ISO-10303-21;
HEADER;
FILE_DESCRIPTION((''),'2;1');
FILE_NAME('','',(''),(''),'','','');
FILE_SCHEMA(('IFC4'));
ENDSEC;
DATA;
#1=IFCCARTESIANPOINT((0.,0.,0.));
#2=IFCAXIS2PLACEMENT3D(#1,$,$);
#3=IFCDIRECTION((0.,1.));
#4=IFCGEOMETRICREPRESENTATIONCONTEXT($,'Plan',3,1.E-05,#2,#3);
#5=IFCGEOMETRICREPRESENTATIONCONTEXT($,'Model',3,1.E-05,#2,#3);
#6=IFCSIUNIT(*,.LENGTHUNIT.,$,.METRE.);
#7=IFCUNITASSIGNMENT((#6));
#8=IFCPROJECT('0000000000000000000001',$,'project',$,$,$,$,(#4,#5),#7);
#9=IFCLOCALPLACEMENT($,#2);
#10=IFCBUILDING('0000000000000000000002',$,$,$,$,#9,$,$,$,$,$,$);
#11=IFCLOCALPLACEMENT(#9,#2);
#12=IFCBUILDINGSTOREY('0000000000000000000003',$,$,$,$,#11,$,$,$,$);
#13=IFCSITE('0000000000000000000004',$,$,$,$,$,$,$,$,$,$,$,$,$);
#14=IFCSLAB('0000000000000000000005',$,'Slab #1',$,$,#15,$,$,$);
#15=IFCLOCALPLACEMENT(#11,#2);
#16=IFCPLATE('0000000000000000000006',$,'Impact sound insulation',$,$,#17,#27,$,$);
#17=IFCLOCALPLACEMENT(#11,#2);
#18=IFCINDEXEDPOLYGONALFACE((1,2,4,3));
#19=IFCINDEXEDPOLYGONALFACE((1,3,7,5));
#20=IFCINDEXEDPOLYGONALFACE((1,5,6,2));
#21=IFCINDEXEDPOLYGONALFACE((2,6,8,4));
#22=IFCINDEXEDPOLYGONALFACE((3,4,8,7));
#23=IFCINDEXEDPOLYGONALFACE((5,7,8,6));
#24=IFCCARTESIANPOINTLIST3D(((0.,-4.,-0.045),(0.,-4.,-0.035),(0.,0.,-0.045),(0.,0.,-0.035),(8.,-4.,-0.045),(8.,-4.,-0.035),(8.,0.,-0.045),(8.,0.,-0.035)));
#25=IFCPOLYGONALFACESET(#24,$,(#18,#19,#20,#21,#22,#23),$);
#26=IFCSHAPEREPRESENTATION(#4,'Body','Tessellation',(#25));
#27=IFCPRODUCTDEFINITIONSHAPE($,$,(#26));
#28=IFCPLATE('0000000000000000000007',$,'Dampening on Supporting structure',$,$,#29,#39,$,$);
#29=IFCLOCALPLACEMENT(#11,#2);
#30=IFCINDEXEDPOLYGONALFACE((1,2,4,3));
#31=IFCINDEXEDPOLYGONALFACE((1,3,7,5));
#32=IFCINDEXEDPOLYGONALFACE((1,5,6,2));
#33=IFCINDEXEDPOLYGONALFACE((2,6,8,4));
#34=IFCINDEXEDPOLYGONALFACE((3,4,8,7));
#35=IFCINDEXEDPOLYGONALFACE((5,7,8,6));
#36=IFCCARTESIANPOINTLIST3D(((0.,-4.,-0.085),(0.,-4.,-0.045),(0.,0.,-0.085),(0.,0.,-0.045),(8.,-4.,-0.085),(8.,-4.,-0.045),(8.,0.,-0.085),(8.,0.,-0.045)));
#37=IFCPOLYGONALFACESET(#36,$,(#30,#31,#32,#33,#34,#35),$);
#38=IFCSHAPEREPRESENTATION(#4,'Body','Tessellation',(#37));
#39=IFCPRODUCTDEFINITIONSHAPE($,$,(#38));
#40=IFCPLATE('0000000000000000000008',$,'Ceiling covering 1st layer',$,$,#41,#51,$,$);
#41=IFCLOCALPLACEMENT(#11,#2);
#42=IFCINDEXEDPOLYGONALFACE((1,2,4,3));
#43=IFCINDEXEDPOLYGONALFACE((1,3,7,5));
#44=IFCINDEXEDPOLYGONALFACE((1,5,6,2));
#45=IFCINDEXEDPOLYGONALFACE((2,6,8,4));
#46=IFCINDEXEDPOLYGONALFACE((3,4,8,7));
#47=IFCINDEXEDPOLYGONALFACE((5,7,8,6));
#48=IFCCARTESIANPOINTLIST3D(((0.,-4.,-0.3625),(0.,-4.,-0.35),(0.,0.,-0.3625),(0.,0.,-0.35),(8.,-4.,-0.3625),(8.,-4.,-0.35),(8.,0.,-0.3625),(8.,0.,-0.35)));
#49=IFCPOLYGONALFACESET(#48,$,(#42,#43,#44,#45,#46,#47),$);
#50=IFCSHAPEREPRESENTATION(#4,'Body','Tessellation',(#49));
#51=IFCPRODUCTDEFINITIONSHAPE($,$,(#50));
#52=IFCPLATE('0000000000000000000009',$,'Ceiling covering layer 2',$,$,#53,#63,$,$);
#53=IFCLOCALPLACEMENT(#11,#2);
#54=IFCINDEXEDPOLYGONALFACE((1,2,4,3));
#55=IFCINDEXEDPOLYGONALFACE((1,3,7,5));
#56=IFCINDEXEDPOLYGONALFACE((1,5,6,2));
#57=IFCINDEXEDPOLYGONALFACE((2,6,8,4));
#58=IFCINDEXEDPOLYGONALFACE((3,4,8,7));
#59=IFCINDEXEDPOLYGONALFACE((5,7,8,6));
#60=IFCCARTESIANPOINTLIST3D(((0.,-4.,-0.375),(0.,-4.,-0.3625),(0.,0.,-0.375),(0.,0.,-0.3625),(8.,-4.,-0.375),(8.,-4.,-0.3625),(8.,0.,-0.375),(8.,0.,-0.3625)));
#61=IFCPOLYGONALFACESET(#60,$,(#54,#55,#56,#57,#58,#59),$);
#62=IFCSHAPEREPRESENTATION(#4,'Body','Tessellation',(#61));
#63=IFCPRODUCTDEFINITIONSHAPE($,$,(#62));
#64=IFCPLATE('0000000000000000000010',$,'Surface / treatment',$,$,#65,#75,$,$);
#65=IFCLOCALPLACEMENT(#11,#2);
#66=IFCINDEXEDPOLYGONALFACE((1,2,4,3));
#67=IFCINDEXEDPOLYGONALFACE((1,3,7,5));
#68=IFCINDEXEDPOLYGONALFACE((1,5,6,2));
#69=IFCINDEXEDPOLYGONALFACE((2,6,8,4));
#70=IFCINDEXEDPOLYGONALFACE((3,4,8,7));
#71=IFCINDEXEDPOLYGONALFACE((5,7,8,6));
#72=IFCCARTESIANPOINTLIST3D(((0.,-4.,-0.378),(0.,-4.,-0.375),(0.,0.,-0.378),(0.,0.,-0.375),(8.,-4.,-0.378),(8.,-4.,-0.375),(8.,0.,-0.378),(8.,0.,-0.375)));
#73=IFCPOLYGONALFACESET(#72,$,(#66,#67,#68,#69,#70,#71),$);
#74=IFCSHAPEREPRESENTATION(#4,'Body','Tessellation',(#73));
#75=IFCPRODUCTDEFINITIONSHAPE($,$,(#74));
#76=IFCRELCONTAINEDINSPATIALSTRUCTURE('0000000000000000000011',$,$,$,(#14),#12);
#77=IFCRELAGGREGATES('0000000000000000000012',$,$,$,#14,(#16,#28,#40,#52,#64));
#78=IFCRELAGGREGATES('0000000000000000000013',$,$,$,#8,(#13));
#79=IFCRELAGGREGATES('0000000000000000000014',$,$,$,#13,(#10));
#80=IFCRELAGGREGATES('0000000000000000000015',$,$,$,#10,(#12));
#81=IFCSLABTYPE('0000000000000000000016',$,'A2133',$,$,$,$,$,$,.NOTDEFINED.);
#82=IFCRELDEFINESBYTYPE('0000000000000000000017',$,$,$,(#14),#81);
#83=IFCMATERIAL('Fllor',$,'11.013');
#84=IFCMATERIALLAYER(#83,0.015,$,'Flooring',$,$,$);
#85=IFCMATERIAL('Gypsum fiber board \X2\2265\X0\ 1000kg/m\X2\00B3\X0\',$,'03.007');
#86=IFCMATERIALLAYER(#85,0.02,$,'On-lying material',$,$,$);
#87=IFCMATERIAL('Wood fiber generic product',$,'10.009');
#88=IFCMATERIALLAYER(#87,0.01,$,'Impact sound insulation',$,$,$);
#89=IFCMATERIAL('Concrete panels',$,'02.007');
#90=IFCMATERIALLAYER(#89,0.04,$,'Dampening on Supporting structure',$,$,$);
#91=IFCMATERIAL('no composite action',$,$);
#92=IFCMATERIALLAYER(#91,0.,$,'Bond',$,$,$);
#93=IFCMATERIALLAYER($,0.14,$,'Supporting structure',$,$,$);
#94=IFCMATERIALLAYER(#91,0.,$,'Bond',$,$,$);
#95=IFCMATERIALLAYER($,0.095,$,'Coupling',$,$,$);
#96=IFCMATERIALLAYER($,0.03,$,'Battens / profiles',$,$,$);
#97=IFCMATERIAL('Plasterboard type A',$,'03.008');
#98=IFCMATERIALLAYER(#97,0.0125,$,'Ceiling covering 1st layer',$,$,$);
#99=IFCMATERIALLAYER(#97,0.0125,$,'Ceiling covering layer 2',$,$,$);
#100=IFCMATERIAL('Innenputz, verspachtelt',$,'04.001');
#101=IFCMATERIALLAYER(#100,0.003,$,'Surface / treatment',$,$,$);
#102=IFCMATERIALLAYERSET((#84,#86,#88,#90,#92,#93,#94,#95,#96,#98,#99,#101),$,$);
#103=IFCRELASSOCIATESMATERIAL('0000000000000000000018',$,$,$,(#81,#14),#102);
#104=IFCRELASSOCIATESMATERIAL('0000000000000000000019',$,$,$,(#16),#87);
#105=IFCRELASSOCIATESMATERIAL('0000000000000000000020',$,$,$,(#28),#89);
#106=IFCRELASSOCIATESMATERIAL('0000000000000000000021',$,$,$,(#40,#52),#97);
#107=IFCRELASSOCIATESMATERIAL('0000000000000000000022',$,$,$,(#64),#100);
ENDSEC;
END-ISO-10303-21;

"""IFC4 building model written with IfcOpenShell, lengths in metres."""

from ifc_helpers import new_model, si_unit, direction, frame, frame_2d, origin, place, context, project, spatial, rectangle, extrude, material, layer, layer_set, type_object, element, aggregate, save


model = new_model("IFC4")

# Units and contexts
plan_context = context("Plan", 3, precision=1e-05, world=origin(), true_north=direction((0.0, 1.0)))
model_context = context("Model", 3, precision=1e-05, world=origin(), true_north=direction((0.0, 1.0)))
ifc_project = project(units=[si_unit("LENGTHUNIT", "METRE")], contexts=[plan_context, model_context])

# Site, building, storey
site = spatial("IfcSite", under=ifc_project)
building_placement = place(None, origin())
building = spatial("IfcBuilding", under=site, at=building_placement)
storey_placement = place(building_placement, origin())
storey = spatial("IfcBuildingStorey", under=building, at=storey_placement)

# Slab, plates
ifc_material_1 = material(Name="Fllor", Category="11.013")
ifc_layer_1 = layer(ifc_material_1, 0.015, Name="Flooring")
ifc_material_2 = material(Name="Gypsum fiber board ≥ 1000kg/m³", Category="03.007")
ifc_layer_2 = layer(ifc_material_2, 0.02, Name="On-lying material")
ifc_material_3 = material(Name="Wood fiber generic product", Category="10.009")
ifc_layer_3 = layer(ifc_material_3, 0.01, Name="Impact sound insulation")
ifc_material_4 = material(Name="Concrete panels", Category="02.007")
ifc_layer_4 = layer(ifc_material_4, 0.04, Name="Dampening on Supporting structure")
ifc_material_5 = material(Name="no composite action")
ifc_layer_5 = layer(ifc_material_5, 0.0, Name="Bond")
ifc_layer_6 = layer(None, 0.14, Name="Supporting structure")
ifc_layer_7 = layer(ifc_material_5, 0.0, Name="Bond")
ifc_layer_8 = layer(None, 0.095, Name="Coupling")
ifc_layer_9 = layer(None, 0.03, Name="Battens / profiles")
ifc_material_6 = material(Name="Plasterboard type A", Category="03.008")
ifc_layer_10 = layer(ifc_material_6, 0.0125, Name="Ceiling covering 1st layer")
ifc_layer_11 = layer(ifc_material_6, 0.0125, Name="Ceiling covering layer 2")
ifc_material_7 = material(Name="Innenputz, verspachtelt", Category="04.001")
ifc_layer_12 = layer(ifc_material_7, 0.003, Name="Surface / treatment")
ifc_layer_set = layer_set([ifc_layer_1, ifc_layer_2, ifc_layer_3, ifc_layer_4, ifc_layer_5, ifc_layer_6, ifc_layer_7, ifc_layer_8, ifc_layer_9, ifc_layer_10, ifc_layer_11, ifc_layer_12])
slab_type = type_object("IfcSlabType", Name="A2133", PredefinedType="NOTDEFINED", material=ifc_layer_set)
slab_placement = place(None, frame((0.0, 0.0, 0.0), z_axis=(0.0, 0.0, -1.0), x_axis=(1.0, 0.0, 0.0)))
slab = element("IfcSlab", 1, at=slab_placement, inside=storey, type_object=slab_type, material=ifc_layer_set, Name="Slab #1")
plate_1_placement = place(slab_placement, origin())
plate_1 = element("IfcPlate", 2, at=plate_1_placement, material=ifc_material_3, Name="Impact sound insulation", context=plan_context, shape_type="SweptSolid", body=[
    extrude(rectangle(XDim=8.0, YDim=4.0, at=frame_2d((4.0, 2.0), x_axis=(1.0, 0.0))), frame((0.0, 0.0, 0.035), z_axis=(0.0, 0.0, 1.0), x_axis=(1.0, 0.0, 0.0)), (0.0, 0.0, 1.0), 0.01),
])
plate_2_placement = place(slab_placement, origin())
plate_2 = element("IfcPlate", 3, at=plate_2_placement, material=ifc_material_4, Name="Dampening on Supporting structure", context=plan_context, shape_type="SweptSolid", body=[
    extrude(rectangle(XDim=8.0, YDim=4.0, at=frame_2d((4.0, 2.0), x_axis=(1.0, 0.0))), frame((0.0, 0.0, 0.045), z_axis=(0.0, 0.0, 1.0), x_axis=(1.0, 0.0, 0.0)), (0.0, 0.0, 1.0), 0.04),
])
plate_3_placement = place(slab_placement, origin())
plate_3 = element("IfcPlate", 4, at=plate_3_placement, material=ifc_material_6, Name="Ceiling covering 1st layer", context=plan_context, shape_type="SweptSolid", body=[
    extrude(rectangle(XDim=8.0, YDim=4.0, at=frame_2d((4.0, 2.0), x_axis=(1.0, 0.0))), frame((0.0, 0.0, 0.35), z_axis=(0.0, 0.0, 1.0), x_axis=(1.0, 0.0, 0.0)), (0.0, 0.0, 1.0), 0.0125),
])
plate_4_placement = place(slab_placement, origin())
plate_4 = element("IfcPlate", 5, at=plate_4_placement, material=ifc_material_6, Name="Ceiling covering layer 2", context=plan_context, shape_type="SweptSolid", body=[
    extrude(rectangle(XDim=8.0, YDim=4.0, at=frame_2d((4.0, 2.0), x_axis=(1.0, 0.0))), frame((0.0, 0.0, 0.3625), z_axis=(0.0, 0.0, 1.0), x_axis=(1.0, 0.0, 0.0)), (0.0, 0.0, 1.0), 0.0125),
])
plate_5_placement = place(slab_placement, origin())
plate_5 = element("IfcPlate", 6, at=plate_5_placement, material=ifc_material_7, Name="Surface / treatment", context=plan_context, shape_type="SweptSolid", body=[
    extrude(rectangle(XDim=8.0, YDim=4.0, at=frame_2d((4.0, 2.0), x_axis=(1.0, 0.0))), frame((0.0, 0.0, 0.375), z_axis=(0.0, 0.0, 1.0), x_axis=(1.0, 0.0, 0.0)), (0.0, 0.0, 1.0), 0.003),
])
aggregate(slab, [plate_1, plate_2, plate_3, plate_4, plate_5])

save(model, "model.ifc")
